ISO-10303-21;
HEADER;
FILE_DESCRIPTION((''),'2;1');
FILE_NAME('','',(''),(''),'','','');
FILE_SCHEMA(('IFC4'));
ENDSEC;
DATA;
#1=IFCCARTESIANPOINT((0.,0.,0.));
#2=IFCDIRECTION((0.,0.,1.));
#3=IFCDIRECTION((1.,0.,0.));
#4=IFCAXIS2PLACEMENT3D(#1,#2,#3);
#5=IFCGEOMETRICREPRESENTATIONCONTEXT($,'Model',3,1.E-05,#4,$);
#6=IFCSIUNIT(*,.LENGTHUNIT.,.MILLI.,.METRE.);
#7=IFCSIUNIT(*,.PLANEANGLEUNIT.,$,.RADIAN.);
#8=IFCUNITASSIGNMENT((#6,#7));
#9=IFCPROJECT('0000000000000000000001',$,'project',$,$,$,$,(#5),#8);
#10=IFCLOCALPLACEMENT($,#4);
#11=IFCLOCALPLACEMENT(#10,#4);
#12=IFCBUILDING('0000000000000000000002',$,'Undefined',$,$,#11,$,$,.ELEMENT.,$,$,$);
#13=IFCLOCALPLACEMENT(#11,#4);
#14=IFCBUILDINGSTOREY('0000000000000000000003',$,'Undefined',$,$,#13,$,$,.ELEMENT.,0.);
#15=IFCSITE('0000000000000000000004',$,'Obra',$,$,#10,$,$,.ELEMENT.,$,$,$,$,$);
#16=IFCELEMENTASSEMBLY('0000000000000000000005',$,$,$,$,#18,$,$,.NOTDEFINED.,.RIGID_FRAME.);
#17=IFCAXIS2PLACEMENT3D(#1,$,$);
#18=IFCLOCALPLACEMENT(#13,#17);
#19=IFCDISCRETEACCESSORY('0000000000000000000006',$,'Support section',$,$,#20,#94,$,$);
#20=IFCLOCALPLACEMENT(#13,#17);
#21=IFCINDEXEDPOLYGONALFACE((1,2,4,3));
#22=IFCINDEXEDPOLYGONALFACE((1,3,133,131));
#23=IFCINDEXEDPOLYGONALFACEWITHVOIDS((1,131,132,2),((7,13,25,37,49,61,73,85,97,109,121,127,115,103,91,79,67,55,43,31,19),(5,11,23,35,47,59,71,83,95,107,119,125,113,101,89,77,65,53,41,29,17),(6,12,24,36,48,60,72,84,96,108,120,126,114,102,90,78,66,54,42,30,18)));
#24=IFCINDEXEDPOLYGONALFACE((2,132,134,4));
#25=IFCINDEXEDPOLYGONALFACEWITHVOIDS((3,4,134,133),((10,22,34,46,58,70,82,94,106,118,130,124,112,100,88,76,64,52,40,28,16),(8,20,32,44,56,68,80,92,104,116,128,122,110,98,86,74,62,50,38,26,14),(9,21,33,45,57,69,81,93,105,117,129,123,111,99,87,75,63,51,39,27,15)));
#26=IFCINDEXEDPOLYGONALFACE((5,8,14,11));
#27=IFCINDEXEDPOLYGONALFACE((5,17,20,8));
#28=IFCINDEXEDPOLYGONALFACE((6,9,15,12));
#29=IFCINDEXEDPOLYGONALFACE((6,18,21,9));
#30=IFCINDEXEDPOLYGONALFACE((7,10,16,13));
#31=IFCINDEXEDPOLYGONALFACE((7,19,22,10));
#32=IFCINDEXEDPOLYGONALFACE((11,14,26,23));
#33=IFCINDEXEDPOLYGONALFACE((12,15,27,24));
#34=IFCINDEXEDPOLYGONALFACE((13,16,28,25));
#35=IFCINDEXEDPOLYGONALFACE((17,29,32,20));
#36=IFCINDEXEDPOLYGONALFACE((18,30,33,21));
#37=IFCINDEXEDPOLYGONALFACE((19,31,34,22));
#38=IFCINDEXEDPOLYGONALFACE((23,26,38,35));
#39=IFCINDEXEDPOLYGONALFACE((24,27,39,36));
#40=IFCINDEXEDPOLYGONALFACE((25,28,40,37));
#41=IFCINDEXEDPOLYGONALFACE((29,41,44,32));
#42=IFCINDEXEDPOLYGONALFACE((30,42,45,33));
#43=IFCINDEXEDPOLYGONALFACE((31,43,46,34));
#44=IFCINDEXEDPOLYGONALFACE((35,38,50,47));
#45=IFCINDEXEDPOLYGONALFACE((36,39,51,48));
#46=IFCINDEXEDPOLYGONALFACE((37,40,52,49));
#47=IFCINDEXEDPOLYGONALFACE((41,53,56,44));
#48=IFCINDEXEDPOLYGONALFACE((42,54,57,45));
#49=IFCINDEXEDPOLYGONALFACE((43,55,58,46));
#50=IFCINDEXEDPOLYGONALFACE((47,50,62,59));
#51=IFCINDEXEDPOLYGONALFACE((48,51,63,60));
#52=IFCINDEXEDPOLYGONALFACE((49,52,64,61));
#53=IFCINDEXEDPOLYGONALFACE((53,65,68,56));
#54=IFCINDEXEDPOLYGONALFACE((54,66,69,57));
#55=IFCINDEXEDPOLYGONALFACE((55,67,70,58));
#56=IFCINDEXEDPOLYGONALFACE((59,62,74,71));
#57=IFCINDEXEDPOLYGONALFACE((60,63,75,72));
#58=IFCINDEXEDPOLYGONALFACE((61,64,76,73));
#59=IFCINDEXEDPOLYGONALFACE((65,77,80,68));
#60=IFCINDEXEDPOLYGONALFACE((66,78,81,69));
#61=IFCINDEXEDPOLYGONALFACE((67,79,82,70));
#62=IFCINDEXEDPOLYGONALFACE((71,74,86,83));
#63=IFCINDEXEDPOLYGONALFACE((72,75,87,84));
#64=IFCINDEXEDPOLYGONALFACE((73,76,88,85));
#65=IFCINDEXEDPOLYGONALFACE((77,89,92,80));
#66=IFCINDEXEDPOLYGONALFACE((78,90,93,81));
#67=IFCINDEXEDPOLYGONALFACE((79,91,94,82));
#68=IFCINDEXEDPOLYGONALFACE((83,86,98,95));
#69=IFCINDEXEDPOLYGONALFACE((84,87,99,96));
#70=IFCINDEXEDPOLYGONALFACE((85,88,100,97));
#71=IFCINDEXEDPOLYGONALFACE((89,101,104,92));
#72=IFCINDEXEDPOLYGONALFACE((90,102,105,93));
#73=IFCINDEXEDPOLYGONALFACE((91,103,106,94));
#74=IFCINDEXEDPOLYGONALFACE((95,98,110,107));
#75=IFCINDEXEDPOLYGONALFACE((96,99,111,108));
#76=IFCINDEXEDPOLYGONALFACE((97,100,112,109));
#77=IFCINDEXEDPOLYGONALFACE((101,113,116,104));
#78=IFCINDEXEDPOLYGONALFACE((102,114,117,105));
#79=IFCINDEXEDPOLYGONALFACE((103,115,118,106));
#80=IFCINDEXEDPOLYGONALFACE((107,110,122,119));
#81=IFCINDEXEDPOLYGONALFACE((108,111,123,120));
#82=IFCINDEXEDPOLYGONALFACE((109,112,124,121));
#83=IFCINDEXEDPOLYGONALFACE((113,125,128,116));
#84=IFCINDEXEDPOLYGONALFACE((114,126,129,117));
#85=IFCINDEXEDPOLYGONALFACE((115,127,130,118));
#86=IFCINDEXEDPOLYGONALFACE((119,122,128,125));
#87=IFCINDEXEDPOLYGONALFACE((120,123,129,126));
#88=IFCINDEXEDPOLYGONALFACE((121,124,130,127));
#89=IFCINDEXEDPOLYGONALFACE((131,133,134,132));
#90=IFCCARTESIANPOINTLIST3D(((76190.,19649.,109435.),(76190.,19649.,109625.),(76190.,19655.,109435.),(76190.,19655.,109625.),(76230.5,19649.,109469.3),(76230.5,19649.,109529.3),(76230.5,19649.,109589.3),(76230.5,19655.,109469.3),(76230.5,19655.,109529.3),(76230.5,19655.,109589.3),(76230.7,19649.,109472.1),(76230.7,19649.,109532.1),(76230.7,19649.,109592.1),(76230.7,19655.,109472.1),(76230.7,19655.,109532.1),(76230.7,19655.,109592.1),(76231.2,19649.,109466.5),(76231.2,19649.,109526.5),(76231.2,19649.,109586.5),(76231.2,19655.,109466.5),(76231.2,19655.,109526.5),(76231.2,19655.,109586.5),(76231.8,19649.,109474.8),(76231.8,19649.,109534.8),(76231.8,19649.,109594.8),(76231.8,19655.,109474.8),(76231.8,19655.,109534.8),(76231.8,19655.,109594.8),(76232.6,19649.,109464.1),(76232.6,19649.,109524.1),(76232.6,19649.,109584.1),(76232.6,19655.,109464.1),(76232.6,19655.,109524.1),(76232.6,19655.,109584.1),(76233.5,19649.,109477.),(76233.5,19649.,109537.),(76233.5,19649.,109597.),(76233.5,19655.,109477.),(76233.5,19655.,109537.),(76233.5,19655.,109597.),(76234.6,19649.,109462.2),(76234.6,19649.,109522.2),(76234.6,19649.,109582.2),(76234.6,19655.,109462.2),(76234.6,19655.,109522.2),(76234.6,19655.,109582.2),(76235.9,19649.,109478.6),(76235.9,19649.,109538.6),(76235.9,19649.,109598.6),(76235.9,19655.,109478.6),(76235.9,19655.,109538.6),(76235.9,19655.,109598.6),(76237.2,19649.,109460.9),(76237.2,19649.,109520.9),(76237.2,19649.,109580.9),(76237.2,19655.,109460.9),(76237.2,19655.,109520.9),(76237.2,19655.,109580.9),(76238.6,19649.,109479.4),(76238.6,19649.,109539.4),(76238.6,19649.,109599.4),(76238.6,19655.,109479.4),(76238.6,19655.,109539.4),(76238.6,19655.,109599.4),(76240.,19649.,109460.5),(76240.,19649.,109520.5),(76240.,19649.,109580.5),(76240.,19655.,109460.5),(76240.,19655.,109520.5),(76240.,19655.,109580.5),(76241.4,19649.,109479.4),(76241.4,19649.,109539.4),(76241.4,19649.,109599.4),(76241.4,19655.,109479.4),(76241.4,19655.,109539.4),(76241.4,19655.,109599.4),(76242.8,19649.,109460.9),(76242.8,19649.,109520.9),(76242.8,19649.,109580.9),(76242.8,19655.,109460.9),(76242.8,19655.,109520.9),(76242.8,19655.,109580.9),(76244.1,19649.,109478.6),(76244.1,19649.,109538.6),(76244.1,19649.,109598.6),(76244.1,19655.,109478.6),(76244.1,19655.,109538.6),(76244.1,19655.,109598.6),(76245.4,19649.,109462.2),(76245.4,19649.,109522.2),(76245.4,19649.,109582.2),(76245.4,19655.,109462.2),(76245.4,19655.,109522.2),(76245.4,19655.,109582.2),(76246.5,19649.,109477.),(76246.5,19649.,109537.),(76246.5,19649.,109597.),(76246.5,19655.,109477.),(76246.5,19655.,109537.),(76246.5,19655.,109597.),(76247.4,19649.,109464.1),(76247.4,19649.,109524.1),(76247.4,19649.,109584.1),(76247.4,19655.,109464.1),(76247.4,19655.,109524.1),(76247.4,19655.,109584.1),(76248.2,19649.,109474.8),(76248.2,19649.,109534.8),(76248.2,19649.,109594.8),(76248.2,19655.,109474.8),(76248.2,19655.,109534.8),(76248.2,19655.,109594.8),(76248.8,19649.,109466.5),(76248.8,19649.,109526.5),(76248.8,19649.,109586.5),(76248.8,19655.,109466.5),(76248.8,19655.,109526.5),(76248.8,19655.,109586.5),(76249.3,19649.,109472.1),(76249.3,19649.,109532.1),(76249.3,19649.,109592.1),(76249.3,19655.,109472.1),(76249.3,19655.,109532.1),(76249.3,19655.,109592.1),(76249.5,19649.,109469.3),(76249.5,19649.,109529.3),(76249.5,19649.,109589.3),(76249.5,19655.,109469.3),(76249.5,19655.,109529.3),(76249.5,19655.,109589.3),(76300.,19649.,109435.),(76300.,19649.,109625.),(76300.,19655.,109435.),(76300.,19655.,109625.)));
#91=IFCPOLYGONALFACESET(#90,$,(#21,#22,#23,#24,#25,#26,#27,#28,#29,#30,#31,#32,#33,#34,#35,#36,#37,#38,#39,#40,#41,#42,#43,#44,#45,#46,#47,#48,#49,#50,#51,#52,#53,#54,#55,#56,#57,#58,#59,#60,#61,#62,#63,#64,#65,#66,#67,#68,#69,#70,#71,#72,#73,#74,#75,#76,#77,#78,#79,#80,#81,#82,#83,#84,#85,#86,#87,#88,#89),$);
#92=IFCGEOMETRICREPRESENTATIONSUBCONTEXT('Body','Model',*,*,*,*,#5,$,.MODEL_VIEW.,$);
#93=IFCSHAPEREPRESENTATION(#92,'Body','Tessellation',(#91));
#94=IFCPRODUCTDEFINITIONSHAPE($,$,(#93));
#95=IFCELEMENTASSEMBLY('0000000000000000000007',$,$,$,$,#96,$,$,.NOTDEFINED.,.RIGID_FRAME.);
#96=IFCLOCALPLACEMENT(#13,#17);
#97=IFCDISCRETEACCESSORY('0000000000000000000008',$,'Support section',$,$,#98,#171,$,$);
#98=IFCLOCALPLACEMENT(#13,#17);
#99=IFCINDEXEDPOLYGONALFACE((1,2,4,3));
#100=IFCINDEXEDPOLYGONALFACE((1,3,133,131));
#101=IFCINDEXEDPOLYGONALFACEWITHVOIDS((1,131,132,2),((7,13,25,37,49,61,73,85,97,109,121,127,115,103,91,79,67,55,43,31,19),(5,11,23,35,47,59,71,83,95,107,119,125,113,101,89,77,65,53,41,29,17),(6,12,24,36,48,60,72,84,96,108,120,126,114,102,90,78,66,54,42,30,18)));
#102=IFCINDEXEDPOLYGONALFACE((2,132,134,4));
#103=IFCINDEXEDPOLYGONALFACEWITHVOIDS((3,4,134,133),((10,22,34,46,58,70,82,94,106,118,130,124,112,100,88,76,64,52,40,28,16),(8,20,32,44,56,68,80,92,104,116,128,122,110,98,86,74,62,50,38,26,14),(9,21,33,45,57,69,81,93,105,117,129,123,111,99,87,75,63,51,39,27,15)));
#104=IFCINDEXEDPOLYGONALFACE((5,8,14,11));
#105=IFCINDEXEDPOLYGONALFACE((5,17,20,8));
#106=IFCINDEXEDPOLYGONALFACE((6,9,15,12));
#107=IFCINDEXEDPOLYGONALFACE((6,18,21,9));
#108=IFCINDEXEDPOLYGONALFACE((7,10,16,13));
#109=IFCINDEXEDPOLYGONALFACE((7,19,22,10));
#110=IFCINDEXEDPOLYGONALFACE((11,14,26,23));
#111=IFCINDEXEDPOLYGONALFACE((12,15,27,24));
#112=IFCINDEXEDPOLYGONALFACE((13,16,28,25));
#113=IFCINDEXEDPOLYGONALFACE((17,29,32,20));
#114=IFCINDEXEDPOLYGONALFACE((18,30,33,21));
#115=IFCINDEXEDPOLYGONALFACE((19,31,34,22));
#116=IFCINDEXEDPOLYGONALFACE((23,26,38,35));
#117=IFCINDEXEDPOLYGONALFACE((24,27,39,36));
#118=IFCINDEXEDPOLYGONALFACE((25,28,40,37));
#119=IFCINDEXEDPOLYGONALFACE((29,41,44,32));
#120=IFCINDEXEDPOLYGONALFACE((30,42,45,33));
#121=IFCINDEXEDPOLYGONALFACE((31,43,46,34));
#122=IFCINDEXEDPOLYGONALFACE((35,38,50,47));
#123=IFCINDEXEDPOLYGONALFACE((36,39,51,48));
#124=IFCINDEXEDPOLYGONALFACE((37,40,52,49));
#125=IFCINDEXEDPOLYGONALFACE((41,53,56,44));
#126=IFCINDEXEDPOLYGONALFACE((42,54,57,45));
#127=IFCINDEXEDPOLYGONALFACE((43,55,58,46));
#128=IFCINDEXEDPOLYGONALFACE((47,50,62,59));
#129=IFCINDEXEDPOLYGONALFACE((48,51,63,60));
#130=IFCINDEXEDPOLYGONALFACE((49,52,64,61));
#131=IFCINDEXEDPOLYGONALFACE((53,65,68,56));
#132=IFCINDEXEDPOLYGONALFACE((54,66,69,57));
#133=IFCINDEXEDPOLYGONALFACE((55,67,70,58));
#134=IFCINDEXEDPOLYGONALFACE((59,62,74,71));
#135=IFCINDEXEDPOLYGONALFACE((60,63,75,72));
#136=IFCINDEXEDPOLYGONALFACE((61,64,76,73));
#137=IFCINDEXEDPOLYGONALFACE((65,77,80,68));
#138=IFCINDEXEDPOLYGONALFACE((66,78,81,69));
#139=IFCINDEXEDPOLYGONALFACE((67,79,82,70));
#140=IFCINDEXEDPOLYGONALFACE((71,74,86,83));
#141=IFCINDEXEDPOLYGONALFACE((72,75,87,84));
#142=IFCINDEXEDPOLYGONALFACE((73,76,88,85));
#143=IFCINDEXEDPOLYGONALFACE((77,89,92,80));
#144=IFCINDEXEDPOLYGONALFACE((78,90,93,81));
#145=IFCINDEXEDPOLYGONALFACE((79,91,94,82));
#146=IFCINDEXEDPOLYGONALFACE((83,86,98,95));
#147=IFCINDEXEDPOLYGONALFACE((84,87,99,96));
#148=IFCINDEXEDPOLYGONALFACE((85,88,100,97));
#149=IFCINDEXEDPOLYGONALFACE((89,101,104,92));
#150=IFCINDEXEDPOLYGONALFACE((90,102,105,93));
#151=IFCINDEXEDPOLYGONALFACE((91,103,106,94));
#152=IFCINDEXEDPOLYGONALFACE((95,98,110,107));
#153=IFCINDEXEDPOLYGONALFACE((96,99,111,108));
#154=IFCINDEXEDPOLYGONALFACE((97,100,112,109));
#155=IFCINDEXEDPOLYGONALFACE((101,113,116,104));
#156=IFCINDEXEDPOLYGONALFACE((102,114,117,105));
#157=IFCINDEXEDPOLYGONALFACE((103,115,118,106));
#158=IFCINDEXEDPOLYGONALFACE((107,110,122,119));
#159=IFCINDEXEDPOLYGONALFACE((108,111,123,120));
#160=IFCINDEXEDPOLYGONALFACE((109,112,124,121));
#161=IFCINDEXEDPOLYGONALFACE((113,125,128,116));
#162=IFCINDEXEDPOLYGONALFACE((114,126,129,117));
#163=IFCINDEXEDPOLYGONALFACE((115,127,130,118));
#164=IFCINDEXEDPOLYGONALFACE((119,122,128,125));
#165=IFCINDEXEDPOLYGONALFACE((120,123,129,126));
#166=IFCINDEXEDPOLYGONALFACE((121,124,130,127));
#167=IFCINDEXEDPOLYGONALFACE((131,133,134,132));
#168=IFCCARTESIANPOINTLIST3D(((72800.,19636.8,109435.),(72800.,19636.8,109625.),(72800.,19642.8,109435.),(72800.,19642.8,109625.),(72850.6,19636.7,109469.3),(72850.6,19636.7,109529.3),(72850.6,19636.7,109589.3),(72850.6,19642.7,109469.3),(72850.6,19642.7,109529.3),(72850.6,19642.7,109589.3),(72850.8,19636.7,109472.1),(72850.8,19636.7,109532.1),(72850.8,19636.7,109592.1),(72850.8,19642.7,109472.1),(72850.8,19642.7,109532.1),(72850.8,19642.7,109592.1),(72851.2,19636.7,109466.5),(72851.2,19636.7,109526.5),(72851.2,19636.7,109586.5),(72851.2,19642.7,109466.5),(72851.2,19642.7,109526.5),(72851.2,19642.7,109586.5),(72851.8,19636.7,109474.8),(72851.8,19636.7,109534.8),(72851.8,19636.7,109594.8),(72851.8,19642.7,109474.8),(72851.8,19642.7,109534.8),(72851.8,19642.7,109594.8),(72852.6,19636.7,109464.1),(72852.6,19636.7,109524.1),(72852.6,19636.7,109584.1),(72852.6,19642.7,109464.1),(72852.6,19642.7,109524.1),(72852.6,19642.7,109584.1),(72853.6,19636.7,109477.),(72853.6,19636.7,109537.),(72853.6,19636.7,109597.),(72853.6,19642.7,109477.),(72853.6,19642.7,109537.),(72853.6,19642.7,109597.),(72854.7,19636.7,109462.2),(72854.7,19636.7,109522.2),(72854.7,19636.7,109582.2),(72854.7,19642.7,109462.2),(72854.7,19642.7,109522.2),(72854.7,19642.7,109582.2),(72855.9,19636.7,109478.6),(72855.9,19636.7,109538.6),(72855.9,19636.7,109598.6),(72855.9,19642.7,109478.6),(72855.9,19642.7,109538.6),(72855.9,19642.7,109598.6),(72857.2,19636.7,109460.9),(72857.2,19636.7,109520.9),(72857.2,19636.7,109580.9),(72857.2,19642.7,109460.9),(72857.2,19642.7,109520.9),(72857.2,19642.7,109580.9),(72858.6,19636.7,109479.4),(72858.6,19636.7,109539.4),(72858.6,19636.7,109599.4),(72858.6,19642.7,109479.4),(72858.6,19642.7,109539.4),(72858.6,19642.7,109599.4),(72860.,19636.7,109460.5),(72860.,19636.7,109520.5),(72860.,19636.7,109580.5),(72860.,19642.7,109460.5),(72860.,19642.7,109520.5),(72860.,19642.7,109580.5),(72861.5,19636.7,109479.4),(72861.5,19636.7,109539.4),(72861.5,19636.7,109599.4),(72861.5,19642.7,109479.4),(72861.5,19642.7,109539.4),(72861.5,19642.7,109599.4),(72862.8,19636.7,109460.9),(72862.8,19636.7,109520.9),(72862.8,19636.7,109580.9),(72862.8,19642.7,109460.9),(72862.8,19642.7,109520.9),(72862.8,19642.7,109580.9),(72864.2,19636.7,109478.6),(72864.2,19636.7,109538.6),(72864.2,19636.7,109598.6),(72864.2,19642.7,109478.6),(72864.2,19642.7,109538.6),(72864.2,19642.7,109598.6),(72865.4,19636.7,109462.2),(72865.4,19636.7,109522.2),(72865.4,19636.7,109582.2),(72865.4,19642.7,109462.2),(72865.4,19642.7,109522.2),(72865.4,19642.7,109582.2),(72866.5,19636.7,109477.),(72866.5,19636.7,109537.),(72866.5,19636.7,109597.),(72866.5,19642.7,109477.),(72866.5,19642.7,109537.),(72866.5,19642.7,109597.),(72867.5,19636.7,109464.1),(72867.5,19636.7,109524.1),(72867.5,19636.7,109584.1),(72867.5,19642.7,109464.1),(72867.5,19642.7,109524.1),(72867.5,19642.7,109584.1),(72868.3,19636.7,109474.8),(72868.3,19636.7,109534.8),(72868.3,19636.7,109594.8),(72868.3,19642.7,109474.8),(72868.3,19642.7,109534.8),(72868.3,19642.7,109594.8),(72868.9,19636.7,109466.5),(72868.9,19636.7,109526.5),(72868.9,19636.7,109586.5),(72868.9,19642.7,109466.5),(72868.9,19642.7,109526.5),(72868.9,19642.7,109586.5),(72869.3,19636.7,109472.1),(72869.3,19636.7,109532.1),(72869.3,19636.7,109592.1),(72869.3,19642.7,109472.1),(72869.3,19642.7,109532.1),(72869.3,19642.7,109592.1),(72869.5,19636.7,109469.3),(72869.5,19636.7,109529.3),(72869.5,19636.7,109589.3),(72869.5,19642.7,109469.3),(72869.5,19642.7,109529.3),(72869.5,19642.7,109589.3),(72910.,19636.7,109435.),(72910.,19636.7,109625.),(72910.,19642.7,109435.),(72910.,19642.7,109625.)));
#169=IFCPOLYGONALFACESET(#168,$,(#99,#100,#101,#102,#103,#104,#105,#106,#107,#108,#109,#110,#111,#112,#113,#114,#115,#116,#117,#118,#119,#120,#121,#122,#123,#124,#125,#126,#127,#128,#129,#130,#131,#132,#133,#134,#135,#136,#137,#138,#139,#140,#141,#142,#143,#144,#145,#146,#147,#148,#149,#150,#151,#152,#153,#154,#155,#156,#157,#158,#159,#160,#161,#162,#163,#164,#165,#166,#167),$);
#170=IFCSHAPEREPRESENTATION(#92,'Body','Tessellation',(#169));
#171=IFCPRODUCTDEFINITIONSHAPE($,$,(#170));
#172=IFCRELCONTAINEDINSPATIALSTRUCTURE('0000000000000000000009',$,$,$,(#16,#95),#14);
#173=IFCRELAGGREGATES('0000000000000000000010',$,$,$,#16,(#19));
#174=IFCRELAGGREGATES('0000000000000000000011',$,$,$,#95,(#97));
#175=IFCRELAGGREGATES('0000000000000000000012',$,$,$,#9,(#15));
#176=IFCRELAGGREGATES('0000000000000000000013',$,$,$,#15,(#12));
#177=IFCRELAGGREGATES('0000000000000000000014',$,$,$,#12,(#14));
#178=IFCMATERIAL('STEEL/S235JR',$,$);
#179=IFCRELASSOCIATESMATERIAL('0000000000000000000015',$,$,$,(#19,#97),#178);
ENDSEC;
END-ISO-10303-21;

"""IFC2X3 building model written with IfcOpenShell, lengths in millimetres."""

from ifc_helpers import new_model, si_unit, frame, origin_with_axes, origin_2d_with_axis, place, context, subcontext, project, spatial, rectangle, circle, extrude, source, transform, mapped, material, element, aggregate, save


model = new_model("IFC2X3")

# Units and contexts
model_context = context("Model", 3, precision=1e-05, world=origin_with_axes())
body_context = subcontext(model_context, "Body", "Model", "MODEL_VIEW")
ifc_project = project(units=[si_unit("LENGTHUNIT", "METRE", prefix="MILLI"), si_unit("PLANEANGLEUNIT", "RADIAN")], contexts=[model_context])

# Site, building, storey
site_placement = place(None, origin_with_axes())
site = spatial("IfcSite", under=ifc_project, at=site_placement, Name="Obra", CompositionType="ELEMENT")
building_placement = place(site_placement, origin_with_axes())
building = spatial("IfcBuilding", under=site, at=building_placement, Name="Undefined", CompositionType="ELEMENT")
storey_placement = place(building_placement, origin_with_axes())
storey = spatial("IfcBuildingStorey", under=building, at=storey_placement, Name="Undefined", CompositionType="ELEMENT", Elevation=0.0)

# Shared definitions
ifc_material_1 = material(Name="STEEL/S235JR")

# Element assemblies, discrete accessories, openings
assembly_1_placement = place(storey_placement, origin_with_axes())
assembly_1 = element("IfcElementAssembly", 1, at=assembly_1_placement, inside=storey, AssemblyPlace="NOTDEFINED", PredefinedType="RIGID_FRAME")
discrete_accessory_1_placement = place(assembly_1_placement, frame((76245.0, 19652.0, 109435.0), z_axis=(0.0, 0.0, 1.0), x_axis=(1.0, 0.0, 0.0)))
discrete_accessory_1 = element("IfcDiscreteAccessory", 2, at=discrete_accessory_1_placement, material=ifc_material_1, Name="Support section", context=body_context, shape_type="SweptSolid", body=[
    extrude(rectangle(XDim=6.0, YDim=110.0, at=origin_2d_with_axis()), frame((0.0, 0.0, 190.0), z_axis=(0.0, 0.0, -1.0), x_axis=(0.0, 1.0, 0.0)), (0.0, 0.0, 1.0), 190.0),
])
shared_shape_1 = source(origin_with_axes(), body_context, "Body", "SweptSolid", [
    extrude(circle(Radius=9.5, at=origin_2d_with_axis()), frame((0.0, -9.2, 0.0), z_axis=(0.0, 1.0, 0.0), x_axis=(1.0, 0.0, 0.0)), (0.0, 0.0, 1.0), 6.2),
])
opening_1_placement = place(assembly_1_placement, frame((76290.0, 19645.9, 109650.0), z_axis=(-1.0, 0.0, 0.0), x_axis=(0.0, 0.0, -1.0)))
element("IfcOpeningElement", 3, at=opening_1_placement, cuts=discrete_accessory_1, ObjectType="Opening", context=body_context, shape_type="MappedRepresentation", body=[
    mapped(shared_shape_1, transform((60.0, 0.0, 50.0))),
    mapped(shared_shape_1, transform((120.0, 0.0, 50.0))),
    mapped(shared_shape_1, transform((180.0, 0.0, 50.0))),
])
aggregate(assembly_1, [discrete_accessory_1])
assembly_2_placement = place(storey_placement, origin_with_axes())
assembly_2 = element("IfcElementAssembly", 4, at=assembly_2_placement, inside=storey, AssemblyPlace="NOTDEFINED", PredefinedType="RIGID_FRAME")
discrete_accessory_2_placement = place(assembly_2_placement, frame((72855.0, 19639.7, 109435.0), z_axis=(0.0, 0.0, 1.0), x_axis=(-1.0, 0.000126, 0.0)))
discrete_accessory_2 = element("IfcDiscreteAccessory", 5, at=discrete_accessory_2_placement, material=ifc_material_1, Name="Support section", context=body_context, shape_type="SweptSolid", body=[
    extrude(rectangle(XDim=6.0, YDim=110.0, at=origin_2d_with_axis()), frame((0.0, 0.0, 190.0), z_axis=(0.0, 0.0, -1.0), x_axis=(0.0, 1.0, 0.0)), (0.0, 0.0, 1.0), 190.0),
])
opening_2_placement = place(assembly_2_placement, frame((72810.0, 19645.8, 109650.0), z_axis=(1.0, -0.000126, 0.0), x_axis=(0.0, 0.0, -1.0)))
element("IfcOpeningElement", 6, at=opening_2_placement, cuts=discrete_accessory_2, ObjectType="Opening", context=body_context, shape_type="MappedRepresentation", body=[
    mapped(shared_shape_1, transform((60.0, 0.0, 50.0))),
    mapped(shared_shape_1, transform((120.0, 0.0, 50.0))),
    mapped(shared_shape_1, transform((180.0, 0.0, 50.0))),
])
aggregate(assembly_2, [discrete_accessory_2])

save(model, "model.ifc")
